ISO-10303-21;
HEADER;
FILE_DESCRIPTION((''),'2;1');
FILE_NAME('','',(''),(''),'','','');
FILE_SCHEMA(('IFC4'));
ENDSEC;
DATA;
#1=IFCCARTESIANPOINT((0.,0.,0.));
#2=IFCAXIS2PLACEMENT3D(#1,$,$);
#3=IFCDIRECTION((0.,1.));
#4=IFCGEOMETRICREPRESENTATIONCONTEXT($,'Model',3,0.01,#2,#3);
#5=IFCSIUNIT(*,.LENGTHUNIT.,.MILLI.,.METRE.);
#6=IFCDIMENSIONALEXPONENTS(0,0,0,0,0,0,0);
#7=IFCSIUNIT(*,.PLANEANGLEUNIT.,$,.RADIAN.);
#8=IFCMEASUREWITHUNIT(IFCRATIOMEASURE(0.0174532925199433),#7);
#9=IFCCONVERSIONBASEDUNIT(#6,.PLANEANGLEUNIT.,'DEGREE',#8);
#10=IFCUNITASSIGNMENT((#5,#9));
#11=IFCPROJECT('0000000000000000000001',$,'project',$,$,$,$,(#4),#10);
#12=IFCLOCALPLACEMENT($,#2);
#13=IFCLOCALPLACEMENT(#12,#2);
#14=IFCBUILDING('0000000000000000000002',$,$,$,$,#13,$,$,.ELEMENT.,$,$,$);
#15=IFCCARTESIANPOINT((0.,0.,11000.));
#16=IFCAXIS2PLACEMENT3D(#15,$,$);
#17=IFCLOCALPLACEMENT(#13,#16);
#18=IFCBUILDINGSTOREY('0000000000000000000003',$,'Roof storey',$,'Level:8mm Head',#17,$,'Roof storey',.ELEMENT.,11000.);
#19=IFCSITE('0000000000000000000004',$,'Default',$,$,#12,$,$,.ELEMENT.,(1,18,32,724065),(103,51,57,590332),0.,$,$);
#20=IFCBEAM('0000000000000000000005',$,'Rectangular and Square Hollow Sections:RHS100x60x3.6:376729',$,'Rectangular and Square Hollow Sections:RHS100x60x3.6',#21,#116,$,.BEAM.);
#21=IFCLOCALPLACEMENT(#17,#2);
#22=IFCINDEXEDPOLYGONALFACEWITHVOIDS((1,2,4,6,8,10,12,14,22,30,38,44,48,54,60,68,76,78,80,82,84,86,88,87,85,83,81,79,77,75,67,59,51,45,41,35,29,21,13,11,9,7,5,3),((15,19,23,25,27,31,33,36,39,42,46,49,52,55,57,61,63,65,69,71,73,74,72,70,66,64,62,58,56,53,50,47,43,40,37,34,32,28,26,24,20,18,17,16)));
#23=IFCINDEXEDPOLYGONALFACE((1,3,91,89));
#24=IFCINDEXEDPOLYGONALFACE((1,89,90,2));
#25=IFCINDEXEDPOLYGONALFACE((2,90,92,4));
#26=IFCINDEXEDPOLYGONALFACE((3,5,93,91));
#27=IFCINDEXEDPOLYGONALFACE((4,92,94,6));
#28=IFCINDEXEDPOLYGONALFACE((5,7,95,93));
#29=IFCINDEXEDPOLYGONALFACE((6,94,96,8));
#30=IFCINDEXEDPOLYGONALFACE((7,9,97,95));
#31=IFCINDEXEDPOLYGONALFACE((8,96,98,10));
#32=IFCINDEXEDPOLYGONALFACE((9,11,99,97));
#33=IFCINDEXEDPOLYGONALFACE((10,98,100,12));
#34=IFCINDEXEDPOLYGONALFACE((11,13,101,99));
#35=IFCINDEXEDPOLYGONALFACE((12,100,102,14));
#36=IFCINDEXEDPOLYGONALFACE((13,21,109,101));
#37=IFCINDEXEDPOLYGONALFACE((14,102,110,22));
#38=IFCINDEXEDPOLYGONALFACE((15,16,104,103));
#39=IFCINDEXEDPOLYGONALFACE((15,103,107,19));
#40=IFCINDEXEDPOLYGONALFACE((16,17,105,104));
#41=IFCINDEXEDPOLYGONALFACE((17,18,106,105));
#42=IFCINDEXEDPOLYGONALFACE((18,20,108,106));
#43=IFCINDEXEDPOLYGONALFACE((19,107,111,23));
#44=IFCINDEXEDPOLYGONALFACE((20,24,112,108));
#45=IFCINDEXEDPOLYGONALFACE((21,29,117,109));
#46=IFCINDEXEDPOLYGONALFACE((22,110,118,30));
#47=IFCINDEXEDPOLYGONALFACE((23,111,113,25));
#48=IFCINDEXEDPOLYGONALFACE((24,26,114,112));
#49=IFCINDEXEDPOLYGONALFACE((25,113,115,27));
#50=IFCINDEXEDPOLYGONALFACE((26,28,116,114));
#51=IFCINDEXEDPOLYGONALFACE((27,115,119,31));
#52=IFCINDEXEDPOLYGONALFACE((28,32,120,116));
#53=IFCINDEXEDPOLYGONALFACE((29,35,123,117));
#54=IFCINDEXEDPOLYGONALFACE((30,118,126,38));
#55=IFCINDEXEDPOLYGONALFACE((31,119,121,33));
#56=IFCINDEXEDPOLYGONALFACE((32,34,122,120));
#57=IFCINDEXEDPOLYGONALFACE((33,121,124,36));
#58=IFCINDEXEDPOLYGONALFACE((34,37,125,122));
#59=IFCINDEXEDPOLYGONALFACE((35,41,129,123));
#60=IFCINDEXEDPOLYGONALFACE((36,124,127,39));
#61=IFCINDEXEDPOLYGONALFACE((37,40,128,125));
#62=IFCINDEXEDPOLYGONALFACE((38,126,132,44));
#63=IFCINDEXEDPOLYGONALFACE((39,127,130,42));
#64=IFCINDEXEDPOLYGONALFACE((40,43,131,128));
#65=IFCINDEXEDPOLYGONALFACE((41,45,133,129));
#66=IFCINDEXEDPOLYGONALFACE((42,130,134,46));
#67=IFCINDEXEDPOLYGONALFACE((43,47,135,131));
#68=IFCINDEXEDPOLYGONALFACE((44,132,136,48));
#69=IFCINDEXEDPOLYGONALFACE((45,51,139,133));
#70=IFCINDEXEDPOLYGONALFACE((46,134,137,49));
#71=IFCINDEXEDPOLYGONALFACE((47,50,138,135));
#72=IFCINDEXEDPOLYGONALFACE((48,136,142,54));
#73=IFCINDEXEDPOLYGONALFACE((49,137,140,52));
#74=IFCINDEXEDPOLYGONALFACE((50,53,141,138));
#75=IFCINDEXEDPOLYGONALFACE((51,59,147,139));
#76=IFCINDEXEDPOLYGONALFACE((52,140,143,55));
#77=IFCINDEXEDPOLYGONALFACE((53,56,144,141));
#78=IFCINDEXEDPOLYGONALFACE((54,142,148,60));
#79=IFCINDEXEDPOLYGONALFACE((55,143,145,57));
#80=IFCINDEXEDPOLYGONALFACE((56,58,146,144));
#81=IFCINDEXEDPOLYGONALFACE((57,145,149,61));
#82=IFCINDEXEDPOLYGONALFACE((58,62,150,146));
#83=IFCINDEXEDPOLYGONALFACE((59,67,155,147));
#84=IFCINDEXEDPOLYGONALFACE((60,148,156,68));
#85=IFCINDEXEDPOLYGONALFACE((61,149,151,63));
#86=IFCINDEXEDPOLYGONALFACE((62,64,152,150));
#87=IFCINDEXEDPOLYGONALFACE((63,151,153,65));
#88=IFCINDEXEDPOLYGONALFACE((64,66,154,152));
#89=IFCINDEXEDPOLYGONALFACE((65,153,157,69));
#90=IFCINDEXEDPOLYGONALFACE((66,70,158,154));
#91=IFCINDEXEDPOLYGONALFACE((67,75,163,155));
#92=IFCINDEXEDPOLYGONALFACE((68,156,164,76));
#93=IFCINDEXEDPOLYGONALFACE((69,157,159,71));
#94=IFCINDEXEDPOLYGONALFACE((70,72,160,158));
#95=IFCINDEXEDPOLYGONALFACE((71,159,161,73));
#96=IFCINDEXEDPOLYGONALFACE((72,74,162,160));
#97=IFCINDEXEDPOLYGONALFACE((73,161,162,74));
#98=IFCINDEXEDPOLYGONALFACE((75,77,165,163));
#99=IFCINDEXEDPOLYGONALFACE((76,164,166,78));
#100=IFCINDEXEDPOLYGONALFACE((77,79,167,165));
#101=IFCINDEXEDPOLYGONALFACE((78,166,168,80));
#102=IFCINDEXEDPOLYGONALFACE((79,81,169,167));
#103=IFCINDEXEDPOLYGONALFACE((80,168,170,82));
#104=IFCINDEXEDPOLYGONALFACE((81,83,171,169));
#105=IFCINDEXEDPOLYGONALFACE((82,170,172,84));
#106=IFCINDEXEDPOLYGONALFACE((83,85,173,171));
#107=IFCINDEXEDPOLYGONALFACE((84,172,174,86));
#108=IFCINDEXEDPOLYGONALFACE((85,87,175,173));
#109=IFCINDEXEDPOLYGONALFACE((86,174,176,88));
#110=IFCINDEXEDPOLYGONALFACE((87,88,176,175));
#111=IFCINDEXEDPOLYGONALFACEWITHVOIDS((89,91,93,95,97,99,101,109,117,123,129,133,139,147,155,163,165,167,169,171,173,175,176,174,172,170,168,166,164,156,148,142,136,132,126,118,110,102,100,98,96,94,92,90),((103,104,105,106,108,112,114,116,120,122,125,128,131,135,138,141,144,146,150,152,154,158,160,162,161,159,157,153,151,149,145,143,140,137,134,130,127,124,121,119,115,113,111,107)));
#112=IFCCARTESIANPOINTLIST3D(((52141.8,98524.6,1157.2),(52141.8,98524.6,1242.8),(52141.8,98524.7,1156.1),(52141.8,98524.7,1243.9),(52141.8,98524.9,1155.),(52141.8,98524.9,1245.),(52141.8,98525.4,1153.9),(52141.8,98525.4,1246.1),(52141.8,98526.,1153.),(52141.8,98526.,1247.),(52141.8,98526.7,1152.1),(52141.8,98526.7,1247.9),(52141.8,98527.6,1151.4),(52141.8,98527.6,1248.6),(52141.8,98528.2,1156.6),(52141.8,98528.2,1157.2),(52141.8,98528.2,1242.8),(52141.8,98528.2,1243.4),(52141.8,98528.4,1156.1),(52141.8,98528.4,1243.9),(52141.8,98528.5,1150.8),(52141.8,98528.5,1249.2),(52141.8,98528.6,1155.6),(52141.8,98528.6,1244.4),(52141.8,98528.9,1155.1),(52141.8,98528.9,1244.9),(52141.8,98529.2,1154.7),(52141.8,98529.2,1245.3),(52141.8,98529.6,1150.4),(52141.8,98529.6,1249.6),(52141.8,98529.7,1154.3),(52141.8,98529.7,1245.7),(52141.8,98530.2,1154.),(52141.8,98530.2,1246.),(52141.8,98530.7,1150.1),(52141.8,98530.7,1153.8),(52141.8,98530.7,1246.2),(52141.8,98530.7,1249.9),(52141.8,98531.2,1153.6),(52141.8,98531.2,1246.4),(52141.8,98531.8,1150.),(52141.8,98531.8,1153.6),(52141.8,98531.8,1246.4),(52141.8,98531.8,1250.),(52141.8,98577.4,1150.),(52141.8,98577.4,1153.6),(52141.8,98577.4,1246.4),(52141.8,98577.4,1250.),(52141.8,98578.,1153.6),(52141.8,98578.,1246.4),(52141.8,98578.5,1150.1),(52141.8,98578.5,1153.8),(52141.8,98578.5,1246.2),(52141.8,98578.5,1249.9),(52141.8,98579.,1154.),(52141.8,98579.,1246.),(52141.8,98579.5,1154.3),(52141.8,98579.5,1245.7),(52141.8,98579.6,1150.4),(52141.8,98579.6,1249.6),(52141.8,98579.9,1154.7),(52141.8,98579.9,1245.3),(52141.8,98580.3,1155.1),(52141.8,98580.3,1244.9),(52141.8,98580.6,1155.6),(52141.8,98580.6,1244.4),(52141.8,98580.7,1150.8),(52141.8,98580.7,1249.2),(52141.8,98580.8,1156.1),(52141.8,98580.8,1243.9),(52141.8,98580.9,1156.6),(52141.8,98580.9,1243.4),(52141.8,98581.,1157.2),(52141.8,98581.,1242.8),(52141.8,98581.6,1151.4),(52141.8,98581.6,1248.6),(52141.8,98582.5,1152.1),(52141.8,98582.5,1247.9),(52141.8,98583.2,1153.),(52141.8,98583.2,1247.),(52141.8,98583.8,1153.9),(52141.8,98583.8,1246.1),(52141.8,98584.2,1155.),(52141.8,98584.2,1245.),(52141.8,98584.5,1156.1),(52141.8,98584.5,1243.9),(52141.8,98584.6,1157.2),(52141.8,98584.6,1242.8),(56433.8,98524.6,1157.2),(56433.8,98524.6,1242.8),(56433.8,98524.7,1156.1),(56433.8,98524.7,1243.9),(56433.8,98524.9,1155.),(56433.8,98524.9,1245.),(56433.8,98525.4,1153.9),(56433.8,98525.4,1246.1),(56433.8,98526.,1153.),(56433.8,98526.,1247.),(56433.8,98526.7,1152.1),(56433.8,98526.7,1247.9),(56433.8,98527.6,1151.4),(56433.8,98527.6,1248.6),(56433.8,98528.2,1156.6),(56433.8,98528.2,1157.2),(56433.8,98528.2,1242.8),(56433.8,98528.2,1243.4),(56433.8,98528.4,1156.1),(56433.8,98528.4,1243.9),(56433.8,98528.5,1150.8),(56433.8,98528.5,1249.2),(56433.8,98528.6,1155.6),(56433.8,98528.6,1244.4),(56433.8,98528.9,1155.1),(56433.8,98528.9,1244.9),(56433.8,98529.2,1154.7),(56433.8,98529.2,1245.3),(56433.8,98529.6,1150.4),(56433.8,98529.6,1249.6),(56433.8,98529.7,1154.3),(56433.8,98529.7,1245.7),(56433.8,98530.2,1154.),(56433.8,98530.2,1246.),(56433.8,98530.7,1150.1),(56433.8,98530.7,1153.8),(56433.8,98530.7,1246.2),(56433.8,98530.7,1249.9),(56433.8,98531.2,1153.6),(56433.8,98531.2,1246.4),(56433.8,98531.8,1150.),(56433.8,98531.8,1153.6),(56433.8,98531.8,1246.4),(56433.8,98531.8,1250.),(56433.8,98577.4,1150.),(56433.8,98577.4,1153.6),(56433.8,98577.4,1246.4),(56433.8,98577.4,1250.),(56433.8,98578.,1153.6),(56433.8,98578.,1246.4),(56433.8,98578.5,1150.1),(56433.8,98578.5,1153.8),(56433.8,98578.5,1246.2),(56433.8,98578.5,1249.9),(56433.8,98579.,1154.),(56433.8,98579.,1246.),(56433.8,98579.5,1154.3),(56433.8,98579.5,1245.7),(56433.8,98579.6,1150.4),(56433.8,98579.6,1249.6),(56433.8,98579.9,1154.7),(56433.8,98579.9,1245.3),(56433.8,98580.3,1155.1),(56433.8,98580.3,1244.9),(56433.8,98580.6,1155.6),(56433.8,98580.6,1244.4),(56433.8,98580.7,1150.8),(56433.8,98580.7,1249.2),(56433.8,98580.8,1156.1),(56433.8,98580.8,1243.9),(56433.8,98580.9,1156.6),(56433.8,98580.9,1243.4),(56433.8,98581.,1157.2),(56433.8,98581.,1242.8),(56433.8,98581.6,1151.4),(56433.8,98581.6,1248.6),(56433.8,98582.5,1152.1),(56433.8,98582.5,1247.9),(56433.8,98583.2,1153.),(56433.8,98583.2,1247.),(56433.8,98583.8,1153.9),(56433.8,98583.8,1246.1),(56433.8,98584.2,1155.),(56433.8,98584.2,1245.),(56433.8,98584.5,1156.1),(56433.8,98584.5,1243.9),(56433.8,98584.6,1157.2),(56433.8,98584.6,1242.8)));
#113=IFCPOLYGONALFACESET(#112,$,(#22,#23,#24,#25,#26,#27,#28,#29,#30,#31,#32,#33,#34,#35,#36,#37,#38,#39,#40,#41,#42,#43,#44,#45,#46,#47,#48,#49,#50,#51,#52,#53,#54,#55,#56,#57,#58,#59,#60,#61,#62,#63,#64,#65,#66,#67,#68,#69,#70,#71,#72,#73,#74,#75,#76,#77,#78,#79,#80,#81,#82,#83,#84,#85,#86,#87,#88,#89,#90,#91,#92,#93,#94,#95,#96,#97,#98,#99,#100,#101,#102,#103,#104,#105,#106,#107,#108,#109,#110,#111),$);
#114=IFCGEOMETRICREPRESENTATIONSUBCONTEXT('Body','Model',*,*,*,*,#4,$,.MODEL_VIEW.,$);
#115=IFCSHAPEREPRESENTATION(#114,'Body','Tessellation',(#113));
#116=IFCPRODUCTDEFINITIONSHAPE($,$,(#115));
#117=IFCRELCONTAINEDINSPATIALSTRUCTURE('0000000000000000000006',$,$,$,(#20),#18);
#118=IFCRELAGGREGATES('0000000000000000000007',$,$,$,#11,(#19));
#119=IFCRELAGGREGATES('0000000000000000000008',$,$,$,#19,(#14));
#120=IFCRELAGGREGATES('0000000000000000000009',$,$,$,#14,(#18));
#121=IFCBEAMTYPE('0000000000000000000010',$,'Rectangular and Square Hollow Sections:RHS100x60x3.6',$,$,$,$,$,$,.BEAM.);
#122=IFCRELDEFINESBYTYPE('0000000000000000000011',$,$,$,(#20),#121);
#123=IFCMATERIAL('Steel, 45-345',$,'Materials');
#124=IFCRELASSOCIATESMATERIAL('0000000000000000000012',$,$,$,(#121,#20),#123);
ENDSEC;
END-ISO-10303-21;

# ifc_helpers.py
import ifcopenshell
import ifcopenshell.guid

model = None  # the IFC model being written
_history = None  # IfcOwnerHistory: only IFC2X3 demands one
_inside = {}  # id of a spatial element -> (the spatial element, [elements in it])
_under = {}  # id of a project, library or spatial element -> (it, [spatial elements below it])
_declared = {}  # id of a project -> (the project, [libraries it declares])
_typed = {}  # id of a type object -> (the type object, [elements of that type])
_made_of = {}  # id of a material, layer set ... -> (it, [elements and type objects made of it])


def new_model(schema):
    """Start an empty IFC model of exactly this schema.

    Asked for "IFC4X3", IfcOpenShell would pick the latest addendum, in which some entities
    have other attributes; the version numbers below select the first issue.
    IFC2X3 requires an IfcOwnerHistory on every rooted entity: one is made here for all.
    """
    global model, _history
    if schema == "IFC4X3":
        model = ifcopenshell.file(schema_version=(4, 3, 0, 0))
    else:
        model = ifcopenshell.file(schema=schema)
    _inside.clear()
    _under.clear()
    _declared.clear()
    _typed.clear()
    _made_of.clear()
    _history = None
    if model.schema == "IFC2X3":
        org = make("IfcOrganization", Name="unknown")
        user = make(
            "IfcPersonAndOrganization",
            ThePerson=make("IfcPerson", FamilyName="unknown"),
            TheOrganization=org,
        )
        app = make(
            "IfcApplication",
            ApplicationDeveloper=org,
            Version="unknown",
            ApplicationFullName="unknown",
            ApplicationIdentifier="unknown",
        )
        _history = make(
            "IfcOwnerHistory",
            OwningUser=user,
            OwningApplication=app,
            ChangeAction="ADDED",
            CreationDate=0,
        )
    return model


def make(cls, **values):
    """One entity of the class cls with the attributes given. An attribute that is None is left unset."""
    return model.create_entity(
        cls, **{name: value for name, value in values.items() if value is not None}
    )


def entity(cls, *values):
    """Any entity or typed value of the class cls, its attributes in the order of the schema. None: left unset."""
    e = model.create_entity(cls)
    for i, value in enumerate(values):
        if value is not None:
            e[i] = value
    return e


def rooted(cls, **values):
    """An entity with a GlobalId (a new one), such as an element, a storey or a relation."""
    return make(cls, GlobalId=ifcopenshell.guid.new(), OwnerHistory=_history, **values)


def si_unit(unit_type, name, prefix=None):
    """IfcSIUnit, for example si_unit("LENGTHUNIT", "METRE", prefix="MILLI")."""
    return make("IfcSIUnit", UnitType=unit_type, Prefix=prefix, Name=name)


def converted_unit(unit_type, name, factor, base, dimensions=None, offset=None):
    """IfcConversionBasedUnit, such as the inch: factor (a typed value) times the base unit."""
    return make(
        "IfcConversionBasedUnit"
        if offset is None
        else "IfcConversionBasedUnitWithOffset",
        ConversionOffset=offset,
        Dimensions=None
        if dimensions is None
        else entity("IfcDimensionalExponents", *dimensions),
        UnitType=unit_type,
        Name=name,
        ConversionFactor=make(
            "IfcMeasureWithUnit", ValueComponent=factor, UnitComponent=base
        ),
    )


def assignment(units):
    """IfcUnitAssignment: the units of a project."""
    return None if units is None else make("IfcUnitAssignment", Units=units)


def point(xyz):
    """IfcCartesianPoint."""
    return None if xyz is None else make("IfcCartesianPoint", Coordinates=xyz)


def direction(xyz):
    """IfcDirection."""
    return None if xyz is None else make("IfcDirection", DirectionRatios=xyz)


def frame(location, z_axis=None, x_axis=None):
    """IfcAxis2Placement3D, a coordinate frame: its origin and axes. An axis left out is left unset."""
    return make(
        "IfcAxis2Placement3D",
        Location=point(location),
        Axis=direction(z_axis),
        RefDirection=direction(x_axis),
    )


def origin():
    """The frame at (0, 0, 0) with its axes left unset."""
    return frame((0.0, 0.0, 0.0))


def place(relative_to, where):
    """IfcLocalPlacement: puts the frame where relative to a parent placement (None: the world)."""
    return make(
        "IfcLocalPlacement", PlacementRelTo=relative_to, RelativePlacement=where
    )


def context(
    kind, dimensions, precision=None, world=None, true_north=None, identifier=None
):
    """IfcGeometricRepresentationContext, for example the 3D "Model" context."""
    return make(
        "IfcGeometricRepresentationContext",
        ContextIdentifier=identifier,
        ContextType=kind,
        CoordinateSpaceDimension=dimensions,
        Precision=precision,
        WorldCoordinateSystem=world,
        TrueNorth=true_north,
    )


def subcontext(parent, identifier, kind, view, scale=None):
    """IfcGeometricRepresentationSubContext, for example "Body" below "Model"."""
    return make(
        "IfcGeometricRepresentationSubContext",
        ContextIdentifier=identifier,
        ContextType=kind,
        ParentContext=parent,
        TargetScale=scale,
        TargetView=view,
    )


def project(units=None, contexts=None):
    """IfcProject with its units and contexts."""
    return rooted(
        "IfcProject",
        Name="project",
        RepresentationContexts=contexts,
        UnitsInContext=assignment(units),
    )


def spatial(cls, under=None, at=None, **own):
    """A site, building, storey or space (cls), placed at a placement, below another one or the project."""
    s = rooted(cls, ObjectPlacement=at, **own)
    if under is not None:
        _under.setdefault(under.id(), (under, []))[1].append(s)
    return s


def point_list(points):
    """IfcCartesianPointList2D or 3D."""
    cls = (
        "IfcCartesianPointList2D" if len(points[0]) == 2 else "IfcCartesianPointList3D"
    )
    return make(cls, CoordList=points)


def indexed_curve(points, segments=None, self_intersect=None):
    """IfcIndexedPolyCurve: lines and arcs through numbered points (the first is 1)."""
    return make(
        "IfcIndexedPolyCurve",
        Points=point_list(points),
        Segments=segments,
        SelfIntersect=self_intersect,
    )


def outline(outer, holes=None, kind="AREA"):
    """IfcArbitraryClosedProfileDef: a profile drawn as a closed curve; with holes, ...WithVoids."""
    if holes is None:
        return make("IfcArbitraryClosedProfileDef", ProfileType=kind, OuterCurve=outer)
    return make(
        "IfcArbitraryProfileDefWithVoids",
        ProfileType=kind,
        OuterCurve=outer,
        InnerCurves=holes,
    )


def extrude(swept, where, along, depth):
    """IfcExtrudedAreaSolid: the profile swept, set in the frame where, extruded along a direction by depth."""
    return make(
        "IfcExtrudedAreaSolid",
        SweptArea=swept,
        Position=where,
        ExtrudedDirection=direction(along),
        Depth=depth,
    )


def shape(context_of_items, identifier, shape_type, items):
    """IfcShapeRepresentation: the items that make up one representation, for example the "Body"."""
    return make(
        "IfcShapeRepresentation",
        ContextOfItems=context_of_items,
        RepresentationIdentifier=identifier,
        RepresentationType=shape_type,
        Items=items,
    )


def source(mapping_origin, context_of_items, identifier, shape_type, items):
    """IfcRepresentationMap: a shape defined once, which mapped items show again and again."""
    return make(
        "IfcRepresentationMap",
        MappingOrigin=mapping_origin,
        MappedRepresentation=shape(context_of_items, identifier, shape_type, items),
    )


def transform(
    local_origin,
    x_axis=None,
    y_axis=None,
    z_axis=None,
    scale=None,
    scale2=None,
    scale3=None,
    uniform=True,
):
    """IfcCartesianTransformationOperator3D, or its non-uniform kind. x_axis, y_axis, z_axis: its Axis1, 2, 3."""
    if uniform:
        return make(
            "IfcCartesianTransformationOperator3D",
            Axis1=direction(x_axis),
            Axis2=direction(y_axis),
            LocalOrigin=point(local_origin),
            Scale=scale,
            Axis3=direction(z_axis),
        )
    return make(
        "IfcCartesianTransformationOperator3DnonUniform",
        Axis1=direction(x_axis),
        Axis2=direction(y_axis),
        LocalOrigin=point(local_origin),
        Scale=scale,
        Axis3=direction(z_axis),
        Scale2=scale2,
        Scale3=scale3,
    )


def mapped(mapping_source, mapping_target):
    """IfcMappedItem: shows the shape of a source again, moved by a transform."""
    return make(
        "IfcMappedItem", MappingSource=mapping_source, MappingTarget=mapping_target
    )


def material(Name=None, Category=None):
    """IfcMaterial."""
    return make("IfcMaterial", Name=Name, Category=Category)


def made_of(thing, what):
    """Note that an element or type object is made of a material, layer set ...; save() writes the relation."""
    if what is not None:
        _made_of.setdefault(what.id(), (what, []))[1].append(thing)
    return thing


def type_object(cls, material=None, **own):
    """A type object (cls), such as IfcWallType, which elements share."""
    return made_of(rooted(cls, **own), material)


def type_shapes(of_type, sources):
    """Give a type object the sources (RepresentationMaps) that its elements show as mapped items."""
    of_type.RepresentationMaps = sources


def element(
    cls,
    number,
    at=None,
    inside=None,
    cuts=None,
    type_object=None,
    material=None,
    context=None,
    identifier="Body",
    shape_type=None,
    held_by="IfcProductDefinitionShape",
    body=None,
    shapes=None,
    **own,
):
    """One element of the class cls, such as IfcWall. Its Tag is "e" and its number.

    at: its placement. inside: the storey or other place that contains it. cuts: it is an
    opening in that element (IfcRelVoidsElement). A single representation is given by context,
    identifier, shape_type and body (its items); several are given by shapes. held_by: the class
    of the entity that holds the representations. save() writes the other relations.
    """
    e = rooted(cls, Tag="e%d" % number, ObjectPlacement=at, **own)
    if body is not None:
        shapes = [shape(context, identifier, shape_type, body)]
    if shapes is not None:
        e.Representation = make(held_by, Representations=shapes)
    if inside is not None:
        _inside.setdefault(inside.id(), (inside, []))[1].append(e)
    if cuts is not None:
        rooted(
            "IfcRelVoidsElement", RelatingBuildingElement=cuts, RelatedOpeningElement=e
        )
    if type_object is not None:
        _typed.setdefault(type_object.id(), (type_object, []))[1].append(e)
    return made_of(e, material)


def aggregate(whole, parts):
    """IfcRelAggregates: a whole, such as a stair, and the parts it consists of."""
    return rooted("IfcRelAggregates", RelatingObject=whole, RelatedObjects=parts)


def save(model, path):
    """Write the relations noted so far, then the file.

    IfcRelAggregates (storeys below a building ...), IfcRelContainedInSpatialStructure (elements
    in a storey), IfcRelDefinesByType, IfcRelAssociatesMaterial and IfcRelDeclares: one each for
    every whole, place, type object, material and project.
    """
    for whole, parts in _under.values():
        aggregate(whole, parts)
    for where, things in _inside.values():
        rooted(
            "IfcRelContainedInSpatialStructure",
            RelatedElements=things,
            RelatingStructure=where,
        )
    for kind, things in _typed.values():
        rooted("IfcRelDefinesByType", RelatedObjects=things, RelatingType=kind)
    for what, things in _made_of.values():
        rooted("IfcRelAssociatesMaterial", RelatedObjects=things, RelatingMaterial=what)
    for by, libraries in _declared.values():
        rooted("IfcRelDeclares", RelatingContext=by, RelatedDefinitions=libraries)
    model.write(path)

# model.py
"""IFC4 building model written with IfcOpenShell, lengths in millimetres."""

from ifc_helpers import new_model, entity, si_unit, converted_unit, direction, frame, origin, place, context, subcontext, project, spatial, indexed_curve, outline, extrude, source, transform, mapped, material, type_object, type_shapes, element, save


model = new_model("IFC4")

# Units and contexts
model_context = context("Model", 3, precision=0.01, world=origin(), true_north=direction((0.0, 1.0)))
body_context = subcontext(model_context, "Body", "Model", "MODEL_VIEW")
ifc_project = project(units=[si_unit("LENGTHUNIT", "METRE", prefix="MILLI"), converted_unit("PLANEANGLEUNIT", "DEGREE", entity("IfcRatioMeasure", 0.0174532925199433), si_unit("PLANEANGLEUNIT", "RADIAN"), dimensions=[0, 0, 0, 0, 0, 0, 0])], contexts=[model_context])

# Site, building, storey
site_placement = place(None, origin())
site = spatial("IfcSite", under=ifc_project, at=site_placement, Name="Default", CompositionType="ELEMENT", RefLatitude=(1, 18, 32, 724065), RefLongitude=(103, 51, 57, 590332), RefElevation=0.0)
building_placement = place(site_placement, origin())
building = spatial("IfcBuilding", under=site, at=building_placement, CompositionType="ELEMENT")
storey_placement = place(building_placement, frame((0.0, 0.0, 11000.0)))
storey = spatial("IfcBuildingStorey", under=building, at=storey_placement, Name="Roof storey", ObjectType="Level:8mm Head", LongName="Roof storey", CompositionType="ELEMENT", Elevation=11000.0)

# Shared definitions
ifc_material = material(Name="Steel, 45-345", Category="Materials")

# Beam
beam_type_1 = type_object("IfcBeamType", Name="Rectangular and Square Hollow Sections:RHS100x60x3.6", PredefinedType="BEAM", material=ifc_material)
shared_shape_1 = source(origin(), body_context, "Body", "SweptSolid", [
    extrude(outline(indexed_curve([(-30.0, -42.8), (-29.9, -43.9), (-29.6, -45.0), (-29.2, -46.1), (-28.6, -47.0), (-27.9, -47.9), (-27.0, -48.6), (-26.1, -49.2), (-25.0, -49.6), (-23.9, -49.9), (-22.8, -50.0), (22.8, -50.0), (23.9, -49.9), (25.0, -49.6), (26.1, -49.2), (27.0, -48.6), (27.9, -47.9), (28.6, -47.0), (29.2, -46.1), (29.6, -45.0), (29.9, -43.9), (30.0, -42.8), (30.0, 42.8), (29.9, 43.9), (29.6, 45.0), (29.2, 46.1), (28.6, 47.0), (27.9, 47.9), (27.0, 48.6), (26.1, 49.2), (25.0, 49.6), (23.9, 49.9), (22.8, 50.0), (-22.8, 50.0), (-23.9, 49.9), (-25.0, 49.6), (-26.1, 49.2), (-27.0, 48.6), (-27.9, 47.9), (-28.6, 47.0), (-29.2, 46.1), (-29.6, 45.0), (-29.9, 43.9), (-30.0, 42.8), (-30.0, -42.8)], self_intersect=False), holes=[indexed_curve([(22.8, -46.4), (-22.8, -46.4), (-23.4, -46.4), (-23.9, -46.2), (-24.4, -46.0), (-24.9, -45.7), (-25.3, -45.3), (-25.7, -44.9), (-26.0, -44.4), (-26.2, -43.9), (-26.4, -43.4), (-26.4, -42.8), (-26.4, 42.8), (-26.4, 43.4), (-26.2, 43.9), (-26.0, 44.4), (-25.7, 44.9), (-25.3, 45.3), (-24.9, 45.7), (-24.4, 46.0), (-23.9, 46.2), (-23.4, 46.4), (-22.8, 46.4), (22.8, 46.4), (23.4, 46.4), (23.9, 46.2), (24.4, 46.0), (24.9, 45.7), (25.3, 45.3), (25.7, 44.9), (26.0, 44.4), (26.2, 43.9), (26.4, 43.4), (26.4, 42.8), (26.4, -42.8), (26.4, -43.4), (26.2, -43.9), (26.0, -44.4), (25.7, -44.9), (25.3, -45.3), (24.9, -45.7), (24.4, -46.0), (23.9, -46.2), (23.4, -46.4), (22.8, -46.4)], self_intersect=False)]), frame((-2152.5, 0.0, 0.0), z_axis=(1.0, 0.0, 0.0), x_axis=(0.0, -1.0, 0.0)), (0.0, 0.0, 1.0), 4292.0),
])
type_shapes(beam_type_1, [shared_shape_1])
for number, where, name in (
    (1, (54294.3, 98554.6, 1200.0), "Rectangular and Square Hollow Sections:RHS100x60x3.6:376729"),
):
    element("IfcBeam", number, at=place(storey_placement, frame(where)), inside=storey, type_object=beam_type_1, material=ifc_material, Name=name, ObjectType="Rectangular and Square Hollow Sections:RHS100x60x3.6", PredefinedType="BEAM", context=body_context, shape_type="MappedRepresentation", body=[
        mapped(shared_shape_1, transform((0.0, 0.0, 0.0), scale=1.0)),
    ])

save(model, "model.ifc")
